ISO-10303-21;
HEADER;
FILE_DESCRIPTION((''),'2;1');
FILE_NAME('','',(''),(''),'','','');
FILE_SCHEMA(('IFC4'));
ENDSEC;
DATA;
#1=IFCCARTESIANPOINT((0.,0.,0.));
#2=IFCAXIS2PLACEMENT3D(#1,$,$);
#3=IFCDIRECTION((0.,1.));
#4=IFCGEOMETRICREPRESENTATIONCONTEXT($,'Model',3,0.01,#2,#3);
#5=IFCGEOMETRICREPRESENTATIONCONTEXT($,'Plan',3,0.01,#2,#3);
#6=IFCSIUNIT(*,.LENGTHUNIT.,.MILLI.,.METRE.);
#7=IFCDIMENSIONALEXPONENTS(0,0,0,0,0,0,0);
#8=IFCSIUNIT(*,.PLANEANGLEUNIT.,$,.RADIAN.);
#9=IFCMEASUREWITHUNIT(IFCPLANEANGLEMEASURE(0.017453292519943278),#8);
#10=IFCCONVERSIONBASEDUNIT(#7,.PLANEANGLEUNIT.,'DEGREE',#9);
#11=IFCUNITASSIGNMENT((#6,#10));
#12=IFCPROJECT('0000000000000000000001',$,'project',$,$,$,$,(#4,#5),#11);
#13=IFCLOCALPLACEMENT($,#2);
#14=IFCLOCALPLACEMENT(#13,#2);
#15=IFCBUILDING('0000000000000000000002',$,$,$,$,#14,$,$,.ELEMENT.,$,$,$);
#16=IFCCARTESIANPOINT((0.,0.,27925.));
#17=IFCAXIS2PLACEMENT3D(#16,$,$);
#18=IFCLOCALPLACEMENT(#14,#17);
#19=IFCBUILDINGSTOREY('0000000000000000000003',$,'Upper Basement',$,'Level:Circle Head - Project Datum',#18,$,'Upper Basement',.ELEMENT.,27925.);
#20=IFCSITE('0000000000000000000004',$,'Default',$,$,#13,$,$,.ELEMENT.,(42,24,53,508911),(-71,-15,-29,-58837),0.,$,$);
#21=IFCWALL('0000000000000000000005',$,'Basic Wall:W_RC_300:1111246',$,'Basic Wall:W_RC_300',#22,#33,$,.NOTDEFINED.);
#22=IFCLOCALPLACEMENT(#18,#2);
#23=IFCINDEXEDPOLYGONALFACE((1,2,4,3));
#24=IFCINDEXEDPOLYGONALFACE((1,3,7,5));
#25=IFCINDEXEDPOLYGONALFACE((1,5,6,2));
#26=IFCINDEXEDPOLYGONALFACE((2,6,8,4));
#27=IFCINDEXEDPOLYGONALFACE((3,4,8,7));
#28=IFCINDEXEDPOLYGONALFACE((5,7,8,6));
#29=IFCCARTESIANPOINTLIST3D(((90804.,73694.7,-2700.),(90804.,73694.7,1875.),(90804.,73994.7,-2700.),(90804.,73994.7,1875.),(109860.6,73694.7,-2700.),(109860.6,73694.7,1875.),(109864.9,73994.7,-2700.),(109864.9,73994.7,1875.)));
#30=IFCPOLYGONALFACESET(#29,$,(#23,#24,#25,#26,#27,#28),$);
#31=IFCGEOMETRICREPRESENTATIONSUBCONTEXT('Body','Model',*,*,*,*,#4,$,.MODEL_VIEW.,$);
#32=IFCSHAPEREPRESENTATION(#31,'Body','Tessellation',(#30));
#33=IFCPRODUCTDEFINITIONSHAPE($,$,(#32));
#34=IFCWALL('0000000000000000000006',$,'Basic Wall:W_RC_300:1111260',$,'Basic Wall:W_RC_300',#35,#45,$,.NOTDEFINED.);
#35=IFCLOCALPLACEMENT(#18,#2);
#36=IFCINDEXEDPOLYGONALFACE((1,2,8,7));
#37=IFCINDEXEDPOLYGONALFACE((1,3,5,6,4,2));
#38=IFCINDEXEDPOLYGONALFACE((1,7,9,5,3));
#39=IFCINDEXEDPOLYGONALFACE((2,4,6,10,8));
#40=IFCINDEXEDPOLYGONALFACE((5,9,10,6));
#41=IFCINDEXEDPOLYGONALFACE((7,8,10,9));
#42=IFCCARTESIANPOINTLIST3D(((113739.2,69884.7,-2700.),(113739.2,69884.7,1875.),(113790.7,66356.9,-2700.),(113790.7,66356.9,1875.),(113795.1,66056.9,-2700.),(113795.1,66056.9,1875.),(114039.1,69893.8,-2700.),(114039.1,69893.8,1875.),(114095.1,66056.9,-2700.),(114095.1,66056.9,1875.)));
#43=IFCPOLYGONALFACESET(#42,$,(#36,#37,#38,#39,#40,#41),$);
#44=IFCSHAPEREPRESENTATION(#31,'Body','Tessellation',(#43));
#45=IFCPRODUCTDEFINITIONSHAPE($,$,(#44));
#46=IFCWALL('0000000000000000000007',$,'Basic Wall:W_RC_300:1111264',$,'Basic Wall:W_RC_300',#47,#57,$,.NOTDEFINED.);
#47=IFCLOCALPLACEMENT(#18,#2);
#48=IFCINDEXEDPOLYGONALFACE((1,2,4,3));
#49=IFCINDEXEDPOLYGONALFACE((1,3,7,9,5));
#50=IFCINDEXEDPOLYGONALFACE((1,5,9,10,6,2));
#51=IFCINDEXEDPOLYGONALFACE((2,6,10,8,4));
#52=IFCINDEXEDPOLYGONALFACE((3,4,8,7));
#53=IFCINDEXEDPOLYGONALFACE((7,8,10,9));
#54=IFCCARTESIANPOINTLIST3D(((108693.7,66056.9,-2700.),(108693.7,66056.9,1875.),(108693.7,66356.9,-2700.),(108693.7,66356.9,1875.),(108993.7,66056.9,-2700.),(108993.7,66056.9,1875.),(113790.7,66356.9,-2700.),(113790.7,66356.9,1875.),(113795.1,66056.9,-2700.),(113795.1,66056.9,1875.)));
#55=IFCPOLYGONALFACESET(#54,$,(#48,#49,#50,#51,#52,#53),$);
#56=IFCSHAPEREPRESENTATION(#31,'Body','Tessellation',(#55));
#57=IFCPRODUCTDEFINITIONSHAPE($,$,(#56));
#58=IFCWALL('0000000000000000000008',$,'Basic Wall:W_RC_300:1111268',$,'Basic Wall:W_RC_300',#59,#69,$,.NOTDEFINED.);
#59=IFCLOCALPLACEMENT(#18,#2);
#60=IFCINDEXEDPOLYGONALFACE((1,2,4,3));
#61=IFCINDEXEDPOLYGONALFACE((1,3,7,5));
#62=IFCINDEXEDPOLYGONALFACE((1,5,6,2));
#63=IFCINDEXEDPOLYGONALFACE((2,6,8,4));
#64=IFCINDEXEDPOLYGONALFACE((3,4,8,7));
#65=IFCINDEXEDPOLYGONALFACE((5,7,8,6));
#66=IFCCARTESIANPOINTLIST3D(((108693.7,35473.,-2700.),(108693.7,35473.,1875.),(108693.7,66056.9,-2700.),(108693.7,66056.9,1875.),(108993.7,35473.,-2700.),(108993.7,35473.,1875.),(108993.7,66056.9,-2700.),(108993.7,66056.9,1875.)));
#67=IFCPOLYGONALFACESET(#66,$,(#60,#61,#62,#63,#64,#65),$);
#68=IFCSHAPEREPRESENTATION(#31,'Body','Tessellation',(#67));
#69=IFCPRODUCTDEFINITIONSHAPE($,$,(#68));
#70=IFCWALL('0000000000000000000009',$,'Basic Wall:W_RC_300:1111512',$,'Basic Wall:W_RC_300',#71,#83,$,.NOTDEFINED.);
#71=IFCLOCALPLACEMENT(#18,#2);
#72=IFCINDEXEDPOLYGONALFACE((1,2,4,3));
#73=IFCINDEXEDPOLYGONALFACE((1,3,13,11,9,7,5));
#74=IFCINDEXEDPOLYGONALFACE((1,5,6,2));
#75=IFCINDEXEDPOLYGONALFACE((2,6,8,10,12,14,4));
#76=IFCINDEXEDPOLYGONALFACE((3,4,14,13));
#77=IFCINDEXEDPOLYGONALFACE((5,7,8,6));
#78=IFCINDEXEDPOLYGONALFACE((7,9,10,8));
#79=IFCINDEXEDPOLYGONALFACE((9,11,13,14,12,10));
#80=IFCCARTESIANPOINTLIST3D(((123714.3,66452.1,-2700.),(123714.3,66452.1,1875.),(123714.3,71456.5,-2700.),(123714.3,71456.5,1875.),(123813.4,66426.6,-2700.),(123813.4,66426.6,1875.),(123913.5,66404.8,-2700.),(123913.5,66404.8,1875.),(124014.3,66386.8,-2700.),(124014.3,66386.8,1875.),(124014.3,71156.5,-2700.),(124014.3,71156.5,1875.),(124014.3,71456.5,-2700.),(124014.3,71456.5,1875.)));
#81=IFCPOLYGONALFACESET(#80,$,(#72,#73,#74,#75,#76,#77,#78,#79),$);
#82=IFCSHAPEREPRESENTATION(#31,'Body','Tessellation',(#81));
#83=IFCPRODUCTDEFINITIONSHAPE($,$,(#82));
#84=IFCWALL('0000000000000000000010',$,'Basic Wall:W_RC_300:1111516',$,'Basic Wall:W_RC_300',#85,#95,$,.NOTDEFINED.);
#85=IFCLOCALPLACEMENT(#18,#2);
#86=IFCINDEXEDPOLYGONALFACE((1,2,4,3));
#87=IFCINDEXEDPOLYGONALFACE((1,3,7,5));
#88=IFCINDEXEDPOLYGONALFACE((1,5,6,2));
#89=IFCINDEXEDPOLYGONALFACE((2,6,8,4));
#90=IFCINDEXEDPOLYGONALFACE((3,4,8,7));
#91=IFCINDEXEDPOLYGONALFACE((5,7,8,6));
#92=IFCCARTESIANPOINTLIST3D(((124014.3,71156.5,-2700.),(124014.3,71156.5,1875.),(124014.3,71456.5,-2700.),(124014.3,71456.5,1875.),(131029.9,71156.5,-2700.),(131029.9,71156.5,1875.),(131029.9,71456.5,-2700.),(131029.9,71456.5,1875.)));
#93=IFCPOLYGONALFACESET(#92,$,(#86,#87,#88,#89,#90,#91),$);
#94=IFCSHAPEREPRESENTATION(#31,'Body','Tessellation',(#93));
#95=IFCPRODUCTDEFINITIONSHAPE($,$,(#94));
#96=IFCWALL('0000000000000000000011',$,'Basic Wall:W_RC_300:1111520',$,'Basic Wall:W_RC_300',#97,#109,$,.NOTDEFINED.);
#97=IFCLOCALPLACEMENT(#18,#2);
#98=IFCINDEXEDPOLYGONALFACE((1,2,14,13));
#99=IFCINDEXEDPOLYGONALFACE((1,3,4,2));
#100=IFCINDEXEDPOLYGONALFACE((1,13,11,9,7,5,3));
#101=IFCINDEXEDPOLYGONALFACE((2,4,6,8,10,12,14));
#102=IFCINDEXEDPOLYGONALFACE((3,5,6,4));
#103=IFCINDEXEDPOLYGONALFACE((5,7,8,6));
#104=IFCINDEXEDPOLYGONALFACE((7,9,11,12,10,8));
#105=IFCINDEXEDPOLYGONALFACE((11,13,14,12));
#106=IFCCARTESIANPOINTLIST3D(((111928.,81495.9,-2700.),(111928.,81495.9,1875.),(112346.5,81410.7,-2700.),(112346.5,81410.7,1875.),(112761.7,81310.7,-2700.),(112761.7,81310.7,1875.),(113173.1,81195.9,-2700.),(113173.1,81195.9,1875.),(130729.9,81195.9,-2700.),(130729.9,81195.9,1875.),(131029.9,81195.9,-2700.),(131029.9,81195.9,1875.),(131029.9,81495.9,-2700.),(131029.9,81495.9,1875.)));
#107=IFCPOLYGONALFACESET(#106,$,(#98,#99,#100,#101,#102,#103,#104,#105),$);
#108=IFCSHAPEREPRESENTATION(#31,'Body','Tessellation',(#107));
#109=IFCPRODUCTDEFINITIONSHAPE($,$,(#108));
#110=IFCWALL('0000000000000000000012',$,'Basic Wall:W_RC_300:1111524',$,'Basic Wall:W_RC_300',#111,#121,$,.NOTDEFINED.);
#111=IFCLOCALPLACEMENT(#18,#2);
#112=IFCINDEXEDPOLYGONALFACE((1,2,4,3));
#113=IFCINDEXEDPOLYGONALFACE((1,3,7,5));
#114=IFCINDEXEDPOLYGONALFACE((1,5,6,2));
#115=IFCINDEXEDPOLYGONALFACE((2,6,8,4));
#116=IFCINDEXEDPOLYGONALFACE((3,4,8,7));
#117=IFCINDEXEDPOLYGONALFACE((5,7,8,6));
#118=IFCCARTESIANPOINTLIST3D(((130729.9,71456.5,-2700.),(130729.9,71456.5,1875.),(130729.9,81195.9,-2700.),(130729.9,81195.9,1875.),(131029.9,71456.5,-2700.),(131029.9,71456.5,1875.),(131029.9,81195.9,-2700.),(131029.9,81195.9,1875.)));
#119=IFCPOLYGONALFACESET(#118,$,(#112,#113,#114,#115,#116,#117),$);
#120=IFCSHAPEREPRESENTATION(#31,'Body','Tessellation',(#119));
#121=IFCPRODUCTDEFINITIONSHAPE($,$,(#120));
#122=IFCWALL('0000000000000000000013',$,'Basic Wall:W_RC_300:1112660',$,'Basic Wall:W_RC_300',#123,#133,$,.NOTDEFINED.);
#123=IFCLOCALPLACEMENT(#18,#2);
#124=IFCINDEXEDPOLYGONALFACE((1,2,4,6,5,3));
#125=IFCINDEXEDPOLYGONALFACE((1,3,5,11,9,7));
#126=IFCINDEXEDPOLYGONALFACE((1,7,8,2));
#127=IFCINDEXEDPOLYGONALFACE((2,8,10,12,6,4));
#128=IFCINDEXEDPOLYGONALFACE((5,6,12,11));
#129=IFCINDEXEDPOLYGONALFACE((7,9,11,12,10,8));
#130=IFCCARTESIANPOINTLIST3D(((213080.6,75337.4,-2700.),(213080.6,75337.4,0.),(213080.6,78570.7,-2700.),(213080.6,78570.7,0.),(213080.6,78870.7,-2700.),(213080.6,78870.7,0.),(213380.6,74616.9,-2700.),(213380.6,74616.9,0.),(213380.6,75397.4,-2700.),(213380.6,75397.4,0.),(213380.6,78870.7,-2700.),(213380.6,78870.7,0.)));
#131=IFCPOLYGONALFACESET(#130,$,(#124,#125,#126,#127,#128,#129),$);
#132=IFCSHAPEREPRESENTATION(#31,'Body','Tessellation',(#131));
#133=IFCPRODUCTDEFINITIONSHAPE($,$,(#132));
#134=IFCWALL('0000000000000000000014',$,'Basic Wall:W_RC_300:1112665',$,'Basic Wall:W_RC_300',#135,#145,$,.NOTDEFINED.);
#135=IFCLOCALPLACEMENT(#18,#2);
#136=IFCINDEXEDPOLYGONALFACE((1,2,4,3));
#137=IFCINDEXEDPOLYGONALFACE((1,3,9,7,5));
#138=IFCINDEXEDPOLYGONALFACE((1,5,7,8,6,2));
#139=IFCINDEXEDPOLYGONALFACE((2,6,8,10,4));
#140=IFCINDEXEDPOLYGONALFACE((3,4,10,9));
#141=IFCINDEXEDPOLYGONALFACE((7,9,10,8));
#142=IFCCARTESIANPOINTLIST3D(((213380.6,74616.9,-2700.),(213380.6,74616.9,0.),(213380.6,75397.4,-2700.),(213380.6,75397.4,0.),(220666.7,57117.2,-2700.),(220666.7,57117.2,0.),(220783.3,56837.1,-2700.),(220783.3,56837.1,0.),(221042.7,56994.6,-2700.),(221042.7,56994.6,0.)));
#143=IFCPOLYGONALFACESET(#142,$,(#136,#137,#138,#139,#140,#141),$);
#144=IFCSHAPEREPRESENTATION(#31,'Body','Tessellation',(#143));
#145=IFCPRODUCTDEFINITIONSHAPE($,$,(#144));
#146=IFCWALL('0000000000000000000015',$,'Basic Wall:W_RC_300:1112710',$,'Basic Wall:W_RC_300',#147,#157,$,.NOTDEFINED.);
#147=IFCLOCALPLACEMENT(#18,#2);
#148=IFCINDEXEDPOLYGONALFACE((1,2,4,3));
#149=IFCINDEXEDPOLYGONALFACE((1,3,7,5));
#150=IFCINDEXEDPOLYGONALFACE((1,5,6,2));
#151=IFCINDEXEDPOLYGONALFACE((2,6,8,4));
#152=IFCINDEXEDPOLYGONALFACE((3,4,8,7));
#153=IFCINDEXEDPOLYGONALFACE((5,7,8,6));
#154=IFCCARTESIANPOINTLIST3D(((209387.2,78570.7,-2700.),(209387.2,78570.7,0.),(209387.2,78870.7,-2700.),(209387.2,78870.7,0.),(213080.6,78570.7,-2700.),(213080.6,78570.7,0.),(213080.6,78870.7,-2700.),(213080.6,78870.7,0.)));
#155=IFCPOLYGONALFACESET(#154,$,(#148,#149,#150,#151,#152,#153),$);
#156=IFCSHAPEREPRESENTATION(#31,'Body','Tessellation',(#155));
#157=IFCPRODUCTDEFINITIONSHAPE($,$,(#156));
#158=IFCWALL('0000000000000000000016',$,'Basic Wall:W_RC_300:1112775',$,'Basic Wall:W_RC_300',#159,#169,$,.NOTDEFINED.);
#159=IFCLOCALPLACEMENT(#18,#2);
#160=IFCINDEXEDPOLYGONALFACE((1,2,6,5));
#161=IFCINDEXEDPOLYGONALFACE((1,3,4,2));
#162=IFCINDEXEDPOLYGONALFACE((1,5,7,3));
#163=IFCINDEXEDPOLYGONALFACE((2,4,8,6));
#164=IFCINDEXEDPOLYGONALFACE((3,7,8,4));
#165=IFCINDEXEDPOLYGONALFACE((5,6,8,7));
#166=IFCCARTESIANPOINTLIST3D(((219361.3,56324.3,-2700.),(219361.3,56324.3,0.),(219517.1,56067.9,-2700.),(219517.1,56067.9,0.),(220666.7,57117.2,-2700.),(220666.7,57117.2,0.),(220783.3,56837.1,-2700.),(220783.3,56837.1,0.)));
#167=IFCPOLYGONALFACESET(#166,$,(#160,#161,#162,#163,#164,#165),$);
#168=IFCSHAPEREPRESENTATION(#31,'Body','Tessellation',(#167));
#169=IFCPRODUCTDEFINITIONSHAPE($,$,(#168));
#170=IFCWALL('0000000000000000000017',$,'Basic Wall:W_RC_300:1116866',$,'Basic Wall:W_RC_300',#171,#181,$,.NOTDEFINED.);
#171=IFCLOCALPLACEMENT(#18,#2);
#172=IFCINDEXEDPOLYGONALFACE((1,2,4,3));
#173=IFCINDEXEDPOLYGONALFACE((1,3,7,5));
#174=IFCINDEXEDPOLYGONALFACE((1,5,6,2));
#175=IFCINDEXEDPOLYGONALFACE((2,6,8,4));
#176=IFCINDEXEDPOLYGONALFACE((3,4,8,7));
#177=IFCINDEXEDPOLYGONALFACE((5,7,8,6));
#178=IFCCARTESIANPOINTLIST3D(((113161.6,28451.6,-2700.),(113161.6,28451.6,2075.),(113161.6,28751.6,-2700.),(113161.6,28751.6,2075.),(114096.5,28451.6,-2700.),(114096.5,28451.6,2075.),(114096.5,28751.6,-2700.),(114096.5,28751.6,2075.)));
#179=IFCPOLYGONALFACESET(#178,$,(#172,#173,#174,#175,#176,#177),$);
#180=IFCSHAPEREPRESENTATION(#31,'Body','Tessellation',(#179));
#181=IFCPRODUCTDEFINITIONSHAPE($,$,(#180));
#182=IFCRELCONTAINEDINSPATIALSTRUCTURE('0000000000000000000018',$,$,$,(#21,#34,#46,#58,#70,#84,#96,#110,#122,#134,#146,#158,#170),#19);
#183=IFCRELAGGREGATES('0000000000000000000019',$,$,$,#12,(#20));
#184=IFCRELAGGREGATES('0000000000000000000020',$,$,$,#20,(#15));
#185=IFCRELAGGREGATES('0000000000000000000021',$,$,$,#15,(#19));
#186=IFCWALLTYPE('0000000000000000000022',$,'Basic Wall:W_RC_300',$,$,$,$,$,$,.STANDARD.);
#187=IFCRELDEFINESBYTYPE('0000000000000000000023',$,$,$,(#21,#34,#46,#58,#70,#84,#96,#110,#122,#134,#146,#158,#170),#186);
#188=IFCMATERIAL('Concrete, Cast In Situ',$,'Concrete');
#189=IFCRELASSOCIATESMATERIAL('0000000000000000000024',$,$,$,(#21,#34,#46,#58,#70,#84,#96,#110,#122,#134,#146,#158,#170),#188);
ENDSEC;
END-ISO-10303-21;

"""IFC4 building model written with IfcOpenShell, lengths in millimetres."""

from ifc_helpers import new_model, entity, si_unit, converted_unit, direction, frame, origin, place, context, subcontext, project, spatial, line, arc, indexed_curve, outline, extrude, material, type_object, element, save


model = new_model("IFC4")

# Units and contexts
model_context = context("Model", 3, precision=0.01, world=origin(), true_north=direction((0.0, 1.0)))
plan_context = context("Plan", 3, precision=0.01, world=origin(), true_north=direction((0.0, 1.0)))
body_context = subcontext(model_context, "Body", "Model", "MODEL_VIEW")
ifc_project = project(units=[si_unit("LENGTHUNIT", "METRE", prefix="MILLI"), converted_unit("PLANEANGLEUNIT", "DEGREE", entity("IfcPlaneAngleMeasure", 0.017453292519943278), si_unit("PLANEANGLEUNIT", "RADIAN"), dimensions=[0, 0, 0, 0, 0, 0, 0])], contexts=[model_context, plan_context])

# Site, building, storey
site_placement = place(None, origin())
site = spatial("IfcSite", under=ifc_project, at=site_placement, Name="Default", CompositionType="ELEMENT", RefLatitude=(42, 24, 53, 508911), RefLongitude=(-71, -15, -29, -58837), RefElevation=0.0)
building_placement = place(site_placement, origin())
building = spatial("IfcBuilding", under=site, at=building_placement, CompositionType="ELEMENT")
storey_placement = place(building_placement, frame((0.0, 0.0, 27925.0)))
storey = spatial("IfcBuildingStorey", under=building, at=storey_placement, Name="Upper Basement", ObjectType="Level:Circle Head - Project Datum", LongName="Upper Basement", CompositionType="ELEMENT", Elevation=27925.0)

# Walls
ifc_material_1 = material(Name="Concrete, Cast In Situ", Category="Concrete")
wall_type = type_object("IfcWallType", Name="Basic Wall:W_RC_300", PredefinedType="STANDARD")
wall_1_placement = place(storey_placement, frame((109864.9, 73844.7, -2700.0), z_axis=(0.0, 0.0, 1.0), x_axis=(-1.0, 0.0, 0.0)))
element("IfcWall", 1, at=wall_1_placement, inside=storey, type_object=wall_type, material=ifc_material_1, Name="Basic Wall:W_RC_300:1111246", ObjectType="Basic Wall:W_RC_300", PredefinedType="NOTDEFINED", context=body_context, shape_type="SweptSolid", body=[
    extrude(outline(indexed_curve([(19060.9, -150.0), (19060.9, 150.0), (4.3, 150.0), (0.0, -150.0), (19060.9, -150.0)], self_intersect=False)), origin(), (0.0, 0.0, 1.0), 4575.0),
])
wall_2_placement = place(storey_placement, frame((113945.1, 66054.8, -2700.0), z_axis=(0.0, 0.0, 1.0), x_axis=(-0.014593, 0.999894, 0.0)))
element("IfcWall", 2, at=wall_2_placement, inside=storey, type_object=wall_type, material=ifc_material_1, Name="Basic Wall:W_RC_300:1111260", ObjectType="Basic Wall:W_RC_300", PredefinedType="NOTDEFINED", context=body_context, shape_type="SweptSolid", body=[
    extrude(outline(indexed_curve([(3837.3, -150.0), (3832.5, 150.0), (304.4, 150.0), (4.4, 150.0), (0.0, -150.0), (3837.3, -150.0)], self_intersect=False)), origin(), (0.0, 0.0, 1.0), 4575.0),
])
wall_3_placement = place(storey_placement, frame((108693.7, 66206.9, -2700.0)))
element("IfcWall", 3, at=wall_3_placement, inside=storey, type_object=wall_type, material=ifc_material_1, Name="Basic Wall:W_RC_300:1111264", ObjectType="Basic Wall:W_RC_300", PredefinedType="NOTDEFINED", context=body_context, shape_type="SweptSolid", body=[
    extrude(outline(indexed_curve([(5101.4, -150.0), (5097.0, 150.0), (0.0, 150.0), (0.0, -150.0), (300.0, -150.0), (5101.4, -150.0)], self_intersect=False)), origin(), (0.0, 0.0, 1.0), 4575.0),
])
wall_4_placement = place(storey_placement, frame((108843.7, 66056.9, -2700.0), z_axis=(0.0, 0.0, 1.0), x_axis=(0.0, -1.0, 0.0)))
element("IfcWall", 4, at=wall_4_placement, inside=storey, type_object=wall_type, material=ifc_material_1, Name="Basic Wall:W_RC_300:1111268", ObjectType="Basic Wall:W_RC_300", PredefinedType="NOTDEFINED", context=body_context, shape_type="SweptSolid", body=[
    extrude(outline(indexed_curve([(30584.0, 150.0), (0.0, 150.0), (0.0, -150.0), (30584.0, -150.0), (30584.0, 150.0)], self_intersect=False)), origin(), (0.0, 0.0, 1.0), 4575.0),
])
wall_5_placement = place(storey_placement, frame((123864.3, 71456.5, -2700.0), z_axis=(0.0, 0.0, 1.0), x_axis=(0.0, -1.0, 0.0)))
element("IfcWall", 5, at=wall_5_placement, inside=storey, type_object=wall_type, material=ifc_material_1, Name="Basic Wall:W_RC_300:1111512", ObjectType="Basic Wall:W_RC_300", PredefinedType="NOTDEFINED", context=body_context, shape_type="SweptSolid", body=[
    extrude(outline(indexed_curve([(5004.3, -150.0), (5041.3, -0.9), (5069.7, 150.0), (300.0, 150.0), (0.0, 150.0), (0.0, -150.0)], segments=[arc(1, 2, 3), line(3, 4, 5, 6, 1)], self_intersect=False)), origin(), (0.0, 0.0, 1.0), 4575.0),
])
wall_6_placement = place(storey_placement, frame((131029.9, 71306.5, -2700.0), z_axis=(0.0, 0.0, 1.0), x_axis=(-1.0, 0.0, 0.0)))
element("IfcWall", 6, at=wall_6_placement, inside=storey, type_object=wall_type, material=ifc_material_1, Name="Basic Wall:W_RC_300:1111516", ObjectType="Basic Wall:W_RC_300", PredefinedType="NOTDEFINED", context=body_context, shape_type="SweptSolid", body=[
    extrude(outline(indexed_curve([(7015.6, 150.0), (0.0, 150.0), (0.0, -150.0), (7015.6, -150.0), (7015.6, 150.0)], self_intersect=False)), origin(), (0.0, 0.0, 1.0), 4575.0),
])
wall_7_placement = place(storey_placement, frame((111928.0, 81345.9, -2700.0)))
element("IfcWall", 7, at=wall_7_placement, inside=storey, type_object=wall_type, material=ifc_material_1, Name="Basic Wall:W_RC_300:1111520", ObjectType="Basic Wall:W_RC_300", PredefinedType="NOTDEFINED", context=body_context, shape_type="SweptSolid", body=[
    extrude(outline(indexed_curve([(19101.9, -150.0), (19101.9, 150.0), (0.0, 150.0), (626.6, 16.6), (1245.1, -150.0), (18801.9, -150.0)], segments=[line(1, 2, 3), arc(3, 4, 5), line(5, 6, 1)], self_intersect=False)), origin(), (0.0, 0.0, 1.0), 4575.0),
])
wall_8_placement = place(storey_placement, frame((130879.9, 81195.9, -2700.0), z_axis=(0.0, 0.0, 1.0), x_axis=(0.0, -1.0, 0.0)))
element("IfcWall", 8, at=wall_8_placement, inside=storey, type_object=wall_type, material=ifc_material_1, Name="Basic Wall:W_RC_300:1111524", ObjectType="Basic Wall:W_RC_300", PredefinedType="NOTDEFINED", context=body_context, shape_type="SweptSolid", body=[
    extrude(outline(indexed_curve([(9739.4, 150.0), (0.0, 150.0), (0.0, -150.0), (9739.4, -150.0), (9739.4, 150.0)], self_intersect=False)), origin(), (0.0, 0.0, 1.0), 4575.0),
])
wall_9_placement = place(storey_placement, frame((213230.6, 78870.7, -2700.0), z_axis=(0.0, 0.0, 1.0), x_axis=(0.0, -1.0, 0.0)))
element("IfcWall", 9, at=wall_9_placement, inside=storey, type_object=wall_type, material=ifc_material_1, Name="Basic Wall:W_RC_300:1112660", ObjectType="Basic Wall:W_RC_300", PredefinedType="NOTDEFINED", context=body_context, shape_type="SweptSolid", body=[
    extrude(outline(indexed_curve([(3533.2, -150.0), (4253.8, 150.0), (3473.3, 150.0), (0.0, 150.0), (0.0, -150.0), (300.0, -150.0), (3533.2, -150.0)], self_intersect=False)), origin(), (0.0, 0.0, 1.0), 2700.0),
])
wall_10_placement = place(storey_placement, frame((213242.1, 75339.7, -2700.0), z_axis=(0.0, 0.0, 1.0), x_axis=(0.384369, -0.923179, 0.0)))
element("IfcWall", 10, at=wall_10_placement, inside=storey, type_object=wall_type, material=ifc_material_1, Name="Basic Wall:W_RC_300:1112665", ObjectType="Basic Wall:W_RC_300", PredefinedType="NOTDEFINED", context=body_context, shape_type="SweptSolid", body=[
    extrude(outline(indexed_curve([(19979.9, -150.0), (19934.1, 150.0), (0.0, 150.0), (720.5, -150.0), (19676.4, -150.0), (19979.9, -150.0)], self_intersect=False)), origin(), (0.0, 0.0, 1.0), 2700.0),
])
wall_11_placement = place(storey_placement, frame((209387.2, 78720.7, -2700.0)))
element("IfcWall", 11, at=wall_11_placement, inside=storey, type_object=wall_type, material=ifc_material_1, Name="Basic Wall:W_RC_300:1112710", ObjectType="Basic Wall:W_RC_300", PredefinedType="NOTDEFINED", context=body_context, shape_type="SweptSolid", body=[
    extrude(outline(indexed_curve([(3693.4, 150.0), (0.0, 150.0), (0.0, -150.0), (3693.4, -150.0), (3693.4, 150.0)], self_intersect=False)), origin(), (0.0, 0.0, 1.0), 2700.0),
])
wall_12_placement = place(storey_placement, frame((220744.5, 56989.0, -2700.0), z_axis=(0.0, 0.0, 1.0), x_axis=(-0.854661, -0.519187, 0.0)))
element("IfcWall", 12, at=wall_12_placement, inside=storey, type_object=wall_type, material=ifc_material_1, Name="Basic Wall:W_RC_300:1112775", ObjectType="Basic Wall:W_RC_300", PredefinedType="NOTDEFINED", context=body_context, shape_type="SweptSolid", body=[
    extrude(outline(indexed_curve([(1527.3, -150.0), (1527.3, 150.0), (45.8, 150.0), (0.0, -150.0), (1527.3, -150.0)], self_intersect=False)), origin(), (0.0, 0.0, 1.0), 2700.0),
])
wall_13_placement = place(storey_placement, frame((114096.5, 28601.6, -2700.0), z_axis=(0.0, 0.0, 1.0), x_axis=(-1.0, 0.0, 0.0)))
element("IfcWall", 13, at=wall_13_placement, inside=storey, type_object=wall_type, material=ifc_material_1, Name="Basic Wall:W_RC_300:1116866", ObjectType="Basic Wall:W_RC_300", PredefinedType="NOTDEFINED", context=body_context, shape_type="SweptSolid", body=[
    extrude(outline(indexed_curve([(934.9, 150.0), (0.0, 150.0), (0.0, -150.0), (934.9, -150.0), (934.9, 150.0)], self_intersect=False)), origin(), (0.0, 0.0, 1.0), 4775.0),
])

save(model, "model.ifc")
